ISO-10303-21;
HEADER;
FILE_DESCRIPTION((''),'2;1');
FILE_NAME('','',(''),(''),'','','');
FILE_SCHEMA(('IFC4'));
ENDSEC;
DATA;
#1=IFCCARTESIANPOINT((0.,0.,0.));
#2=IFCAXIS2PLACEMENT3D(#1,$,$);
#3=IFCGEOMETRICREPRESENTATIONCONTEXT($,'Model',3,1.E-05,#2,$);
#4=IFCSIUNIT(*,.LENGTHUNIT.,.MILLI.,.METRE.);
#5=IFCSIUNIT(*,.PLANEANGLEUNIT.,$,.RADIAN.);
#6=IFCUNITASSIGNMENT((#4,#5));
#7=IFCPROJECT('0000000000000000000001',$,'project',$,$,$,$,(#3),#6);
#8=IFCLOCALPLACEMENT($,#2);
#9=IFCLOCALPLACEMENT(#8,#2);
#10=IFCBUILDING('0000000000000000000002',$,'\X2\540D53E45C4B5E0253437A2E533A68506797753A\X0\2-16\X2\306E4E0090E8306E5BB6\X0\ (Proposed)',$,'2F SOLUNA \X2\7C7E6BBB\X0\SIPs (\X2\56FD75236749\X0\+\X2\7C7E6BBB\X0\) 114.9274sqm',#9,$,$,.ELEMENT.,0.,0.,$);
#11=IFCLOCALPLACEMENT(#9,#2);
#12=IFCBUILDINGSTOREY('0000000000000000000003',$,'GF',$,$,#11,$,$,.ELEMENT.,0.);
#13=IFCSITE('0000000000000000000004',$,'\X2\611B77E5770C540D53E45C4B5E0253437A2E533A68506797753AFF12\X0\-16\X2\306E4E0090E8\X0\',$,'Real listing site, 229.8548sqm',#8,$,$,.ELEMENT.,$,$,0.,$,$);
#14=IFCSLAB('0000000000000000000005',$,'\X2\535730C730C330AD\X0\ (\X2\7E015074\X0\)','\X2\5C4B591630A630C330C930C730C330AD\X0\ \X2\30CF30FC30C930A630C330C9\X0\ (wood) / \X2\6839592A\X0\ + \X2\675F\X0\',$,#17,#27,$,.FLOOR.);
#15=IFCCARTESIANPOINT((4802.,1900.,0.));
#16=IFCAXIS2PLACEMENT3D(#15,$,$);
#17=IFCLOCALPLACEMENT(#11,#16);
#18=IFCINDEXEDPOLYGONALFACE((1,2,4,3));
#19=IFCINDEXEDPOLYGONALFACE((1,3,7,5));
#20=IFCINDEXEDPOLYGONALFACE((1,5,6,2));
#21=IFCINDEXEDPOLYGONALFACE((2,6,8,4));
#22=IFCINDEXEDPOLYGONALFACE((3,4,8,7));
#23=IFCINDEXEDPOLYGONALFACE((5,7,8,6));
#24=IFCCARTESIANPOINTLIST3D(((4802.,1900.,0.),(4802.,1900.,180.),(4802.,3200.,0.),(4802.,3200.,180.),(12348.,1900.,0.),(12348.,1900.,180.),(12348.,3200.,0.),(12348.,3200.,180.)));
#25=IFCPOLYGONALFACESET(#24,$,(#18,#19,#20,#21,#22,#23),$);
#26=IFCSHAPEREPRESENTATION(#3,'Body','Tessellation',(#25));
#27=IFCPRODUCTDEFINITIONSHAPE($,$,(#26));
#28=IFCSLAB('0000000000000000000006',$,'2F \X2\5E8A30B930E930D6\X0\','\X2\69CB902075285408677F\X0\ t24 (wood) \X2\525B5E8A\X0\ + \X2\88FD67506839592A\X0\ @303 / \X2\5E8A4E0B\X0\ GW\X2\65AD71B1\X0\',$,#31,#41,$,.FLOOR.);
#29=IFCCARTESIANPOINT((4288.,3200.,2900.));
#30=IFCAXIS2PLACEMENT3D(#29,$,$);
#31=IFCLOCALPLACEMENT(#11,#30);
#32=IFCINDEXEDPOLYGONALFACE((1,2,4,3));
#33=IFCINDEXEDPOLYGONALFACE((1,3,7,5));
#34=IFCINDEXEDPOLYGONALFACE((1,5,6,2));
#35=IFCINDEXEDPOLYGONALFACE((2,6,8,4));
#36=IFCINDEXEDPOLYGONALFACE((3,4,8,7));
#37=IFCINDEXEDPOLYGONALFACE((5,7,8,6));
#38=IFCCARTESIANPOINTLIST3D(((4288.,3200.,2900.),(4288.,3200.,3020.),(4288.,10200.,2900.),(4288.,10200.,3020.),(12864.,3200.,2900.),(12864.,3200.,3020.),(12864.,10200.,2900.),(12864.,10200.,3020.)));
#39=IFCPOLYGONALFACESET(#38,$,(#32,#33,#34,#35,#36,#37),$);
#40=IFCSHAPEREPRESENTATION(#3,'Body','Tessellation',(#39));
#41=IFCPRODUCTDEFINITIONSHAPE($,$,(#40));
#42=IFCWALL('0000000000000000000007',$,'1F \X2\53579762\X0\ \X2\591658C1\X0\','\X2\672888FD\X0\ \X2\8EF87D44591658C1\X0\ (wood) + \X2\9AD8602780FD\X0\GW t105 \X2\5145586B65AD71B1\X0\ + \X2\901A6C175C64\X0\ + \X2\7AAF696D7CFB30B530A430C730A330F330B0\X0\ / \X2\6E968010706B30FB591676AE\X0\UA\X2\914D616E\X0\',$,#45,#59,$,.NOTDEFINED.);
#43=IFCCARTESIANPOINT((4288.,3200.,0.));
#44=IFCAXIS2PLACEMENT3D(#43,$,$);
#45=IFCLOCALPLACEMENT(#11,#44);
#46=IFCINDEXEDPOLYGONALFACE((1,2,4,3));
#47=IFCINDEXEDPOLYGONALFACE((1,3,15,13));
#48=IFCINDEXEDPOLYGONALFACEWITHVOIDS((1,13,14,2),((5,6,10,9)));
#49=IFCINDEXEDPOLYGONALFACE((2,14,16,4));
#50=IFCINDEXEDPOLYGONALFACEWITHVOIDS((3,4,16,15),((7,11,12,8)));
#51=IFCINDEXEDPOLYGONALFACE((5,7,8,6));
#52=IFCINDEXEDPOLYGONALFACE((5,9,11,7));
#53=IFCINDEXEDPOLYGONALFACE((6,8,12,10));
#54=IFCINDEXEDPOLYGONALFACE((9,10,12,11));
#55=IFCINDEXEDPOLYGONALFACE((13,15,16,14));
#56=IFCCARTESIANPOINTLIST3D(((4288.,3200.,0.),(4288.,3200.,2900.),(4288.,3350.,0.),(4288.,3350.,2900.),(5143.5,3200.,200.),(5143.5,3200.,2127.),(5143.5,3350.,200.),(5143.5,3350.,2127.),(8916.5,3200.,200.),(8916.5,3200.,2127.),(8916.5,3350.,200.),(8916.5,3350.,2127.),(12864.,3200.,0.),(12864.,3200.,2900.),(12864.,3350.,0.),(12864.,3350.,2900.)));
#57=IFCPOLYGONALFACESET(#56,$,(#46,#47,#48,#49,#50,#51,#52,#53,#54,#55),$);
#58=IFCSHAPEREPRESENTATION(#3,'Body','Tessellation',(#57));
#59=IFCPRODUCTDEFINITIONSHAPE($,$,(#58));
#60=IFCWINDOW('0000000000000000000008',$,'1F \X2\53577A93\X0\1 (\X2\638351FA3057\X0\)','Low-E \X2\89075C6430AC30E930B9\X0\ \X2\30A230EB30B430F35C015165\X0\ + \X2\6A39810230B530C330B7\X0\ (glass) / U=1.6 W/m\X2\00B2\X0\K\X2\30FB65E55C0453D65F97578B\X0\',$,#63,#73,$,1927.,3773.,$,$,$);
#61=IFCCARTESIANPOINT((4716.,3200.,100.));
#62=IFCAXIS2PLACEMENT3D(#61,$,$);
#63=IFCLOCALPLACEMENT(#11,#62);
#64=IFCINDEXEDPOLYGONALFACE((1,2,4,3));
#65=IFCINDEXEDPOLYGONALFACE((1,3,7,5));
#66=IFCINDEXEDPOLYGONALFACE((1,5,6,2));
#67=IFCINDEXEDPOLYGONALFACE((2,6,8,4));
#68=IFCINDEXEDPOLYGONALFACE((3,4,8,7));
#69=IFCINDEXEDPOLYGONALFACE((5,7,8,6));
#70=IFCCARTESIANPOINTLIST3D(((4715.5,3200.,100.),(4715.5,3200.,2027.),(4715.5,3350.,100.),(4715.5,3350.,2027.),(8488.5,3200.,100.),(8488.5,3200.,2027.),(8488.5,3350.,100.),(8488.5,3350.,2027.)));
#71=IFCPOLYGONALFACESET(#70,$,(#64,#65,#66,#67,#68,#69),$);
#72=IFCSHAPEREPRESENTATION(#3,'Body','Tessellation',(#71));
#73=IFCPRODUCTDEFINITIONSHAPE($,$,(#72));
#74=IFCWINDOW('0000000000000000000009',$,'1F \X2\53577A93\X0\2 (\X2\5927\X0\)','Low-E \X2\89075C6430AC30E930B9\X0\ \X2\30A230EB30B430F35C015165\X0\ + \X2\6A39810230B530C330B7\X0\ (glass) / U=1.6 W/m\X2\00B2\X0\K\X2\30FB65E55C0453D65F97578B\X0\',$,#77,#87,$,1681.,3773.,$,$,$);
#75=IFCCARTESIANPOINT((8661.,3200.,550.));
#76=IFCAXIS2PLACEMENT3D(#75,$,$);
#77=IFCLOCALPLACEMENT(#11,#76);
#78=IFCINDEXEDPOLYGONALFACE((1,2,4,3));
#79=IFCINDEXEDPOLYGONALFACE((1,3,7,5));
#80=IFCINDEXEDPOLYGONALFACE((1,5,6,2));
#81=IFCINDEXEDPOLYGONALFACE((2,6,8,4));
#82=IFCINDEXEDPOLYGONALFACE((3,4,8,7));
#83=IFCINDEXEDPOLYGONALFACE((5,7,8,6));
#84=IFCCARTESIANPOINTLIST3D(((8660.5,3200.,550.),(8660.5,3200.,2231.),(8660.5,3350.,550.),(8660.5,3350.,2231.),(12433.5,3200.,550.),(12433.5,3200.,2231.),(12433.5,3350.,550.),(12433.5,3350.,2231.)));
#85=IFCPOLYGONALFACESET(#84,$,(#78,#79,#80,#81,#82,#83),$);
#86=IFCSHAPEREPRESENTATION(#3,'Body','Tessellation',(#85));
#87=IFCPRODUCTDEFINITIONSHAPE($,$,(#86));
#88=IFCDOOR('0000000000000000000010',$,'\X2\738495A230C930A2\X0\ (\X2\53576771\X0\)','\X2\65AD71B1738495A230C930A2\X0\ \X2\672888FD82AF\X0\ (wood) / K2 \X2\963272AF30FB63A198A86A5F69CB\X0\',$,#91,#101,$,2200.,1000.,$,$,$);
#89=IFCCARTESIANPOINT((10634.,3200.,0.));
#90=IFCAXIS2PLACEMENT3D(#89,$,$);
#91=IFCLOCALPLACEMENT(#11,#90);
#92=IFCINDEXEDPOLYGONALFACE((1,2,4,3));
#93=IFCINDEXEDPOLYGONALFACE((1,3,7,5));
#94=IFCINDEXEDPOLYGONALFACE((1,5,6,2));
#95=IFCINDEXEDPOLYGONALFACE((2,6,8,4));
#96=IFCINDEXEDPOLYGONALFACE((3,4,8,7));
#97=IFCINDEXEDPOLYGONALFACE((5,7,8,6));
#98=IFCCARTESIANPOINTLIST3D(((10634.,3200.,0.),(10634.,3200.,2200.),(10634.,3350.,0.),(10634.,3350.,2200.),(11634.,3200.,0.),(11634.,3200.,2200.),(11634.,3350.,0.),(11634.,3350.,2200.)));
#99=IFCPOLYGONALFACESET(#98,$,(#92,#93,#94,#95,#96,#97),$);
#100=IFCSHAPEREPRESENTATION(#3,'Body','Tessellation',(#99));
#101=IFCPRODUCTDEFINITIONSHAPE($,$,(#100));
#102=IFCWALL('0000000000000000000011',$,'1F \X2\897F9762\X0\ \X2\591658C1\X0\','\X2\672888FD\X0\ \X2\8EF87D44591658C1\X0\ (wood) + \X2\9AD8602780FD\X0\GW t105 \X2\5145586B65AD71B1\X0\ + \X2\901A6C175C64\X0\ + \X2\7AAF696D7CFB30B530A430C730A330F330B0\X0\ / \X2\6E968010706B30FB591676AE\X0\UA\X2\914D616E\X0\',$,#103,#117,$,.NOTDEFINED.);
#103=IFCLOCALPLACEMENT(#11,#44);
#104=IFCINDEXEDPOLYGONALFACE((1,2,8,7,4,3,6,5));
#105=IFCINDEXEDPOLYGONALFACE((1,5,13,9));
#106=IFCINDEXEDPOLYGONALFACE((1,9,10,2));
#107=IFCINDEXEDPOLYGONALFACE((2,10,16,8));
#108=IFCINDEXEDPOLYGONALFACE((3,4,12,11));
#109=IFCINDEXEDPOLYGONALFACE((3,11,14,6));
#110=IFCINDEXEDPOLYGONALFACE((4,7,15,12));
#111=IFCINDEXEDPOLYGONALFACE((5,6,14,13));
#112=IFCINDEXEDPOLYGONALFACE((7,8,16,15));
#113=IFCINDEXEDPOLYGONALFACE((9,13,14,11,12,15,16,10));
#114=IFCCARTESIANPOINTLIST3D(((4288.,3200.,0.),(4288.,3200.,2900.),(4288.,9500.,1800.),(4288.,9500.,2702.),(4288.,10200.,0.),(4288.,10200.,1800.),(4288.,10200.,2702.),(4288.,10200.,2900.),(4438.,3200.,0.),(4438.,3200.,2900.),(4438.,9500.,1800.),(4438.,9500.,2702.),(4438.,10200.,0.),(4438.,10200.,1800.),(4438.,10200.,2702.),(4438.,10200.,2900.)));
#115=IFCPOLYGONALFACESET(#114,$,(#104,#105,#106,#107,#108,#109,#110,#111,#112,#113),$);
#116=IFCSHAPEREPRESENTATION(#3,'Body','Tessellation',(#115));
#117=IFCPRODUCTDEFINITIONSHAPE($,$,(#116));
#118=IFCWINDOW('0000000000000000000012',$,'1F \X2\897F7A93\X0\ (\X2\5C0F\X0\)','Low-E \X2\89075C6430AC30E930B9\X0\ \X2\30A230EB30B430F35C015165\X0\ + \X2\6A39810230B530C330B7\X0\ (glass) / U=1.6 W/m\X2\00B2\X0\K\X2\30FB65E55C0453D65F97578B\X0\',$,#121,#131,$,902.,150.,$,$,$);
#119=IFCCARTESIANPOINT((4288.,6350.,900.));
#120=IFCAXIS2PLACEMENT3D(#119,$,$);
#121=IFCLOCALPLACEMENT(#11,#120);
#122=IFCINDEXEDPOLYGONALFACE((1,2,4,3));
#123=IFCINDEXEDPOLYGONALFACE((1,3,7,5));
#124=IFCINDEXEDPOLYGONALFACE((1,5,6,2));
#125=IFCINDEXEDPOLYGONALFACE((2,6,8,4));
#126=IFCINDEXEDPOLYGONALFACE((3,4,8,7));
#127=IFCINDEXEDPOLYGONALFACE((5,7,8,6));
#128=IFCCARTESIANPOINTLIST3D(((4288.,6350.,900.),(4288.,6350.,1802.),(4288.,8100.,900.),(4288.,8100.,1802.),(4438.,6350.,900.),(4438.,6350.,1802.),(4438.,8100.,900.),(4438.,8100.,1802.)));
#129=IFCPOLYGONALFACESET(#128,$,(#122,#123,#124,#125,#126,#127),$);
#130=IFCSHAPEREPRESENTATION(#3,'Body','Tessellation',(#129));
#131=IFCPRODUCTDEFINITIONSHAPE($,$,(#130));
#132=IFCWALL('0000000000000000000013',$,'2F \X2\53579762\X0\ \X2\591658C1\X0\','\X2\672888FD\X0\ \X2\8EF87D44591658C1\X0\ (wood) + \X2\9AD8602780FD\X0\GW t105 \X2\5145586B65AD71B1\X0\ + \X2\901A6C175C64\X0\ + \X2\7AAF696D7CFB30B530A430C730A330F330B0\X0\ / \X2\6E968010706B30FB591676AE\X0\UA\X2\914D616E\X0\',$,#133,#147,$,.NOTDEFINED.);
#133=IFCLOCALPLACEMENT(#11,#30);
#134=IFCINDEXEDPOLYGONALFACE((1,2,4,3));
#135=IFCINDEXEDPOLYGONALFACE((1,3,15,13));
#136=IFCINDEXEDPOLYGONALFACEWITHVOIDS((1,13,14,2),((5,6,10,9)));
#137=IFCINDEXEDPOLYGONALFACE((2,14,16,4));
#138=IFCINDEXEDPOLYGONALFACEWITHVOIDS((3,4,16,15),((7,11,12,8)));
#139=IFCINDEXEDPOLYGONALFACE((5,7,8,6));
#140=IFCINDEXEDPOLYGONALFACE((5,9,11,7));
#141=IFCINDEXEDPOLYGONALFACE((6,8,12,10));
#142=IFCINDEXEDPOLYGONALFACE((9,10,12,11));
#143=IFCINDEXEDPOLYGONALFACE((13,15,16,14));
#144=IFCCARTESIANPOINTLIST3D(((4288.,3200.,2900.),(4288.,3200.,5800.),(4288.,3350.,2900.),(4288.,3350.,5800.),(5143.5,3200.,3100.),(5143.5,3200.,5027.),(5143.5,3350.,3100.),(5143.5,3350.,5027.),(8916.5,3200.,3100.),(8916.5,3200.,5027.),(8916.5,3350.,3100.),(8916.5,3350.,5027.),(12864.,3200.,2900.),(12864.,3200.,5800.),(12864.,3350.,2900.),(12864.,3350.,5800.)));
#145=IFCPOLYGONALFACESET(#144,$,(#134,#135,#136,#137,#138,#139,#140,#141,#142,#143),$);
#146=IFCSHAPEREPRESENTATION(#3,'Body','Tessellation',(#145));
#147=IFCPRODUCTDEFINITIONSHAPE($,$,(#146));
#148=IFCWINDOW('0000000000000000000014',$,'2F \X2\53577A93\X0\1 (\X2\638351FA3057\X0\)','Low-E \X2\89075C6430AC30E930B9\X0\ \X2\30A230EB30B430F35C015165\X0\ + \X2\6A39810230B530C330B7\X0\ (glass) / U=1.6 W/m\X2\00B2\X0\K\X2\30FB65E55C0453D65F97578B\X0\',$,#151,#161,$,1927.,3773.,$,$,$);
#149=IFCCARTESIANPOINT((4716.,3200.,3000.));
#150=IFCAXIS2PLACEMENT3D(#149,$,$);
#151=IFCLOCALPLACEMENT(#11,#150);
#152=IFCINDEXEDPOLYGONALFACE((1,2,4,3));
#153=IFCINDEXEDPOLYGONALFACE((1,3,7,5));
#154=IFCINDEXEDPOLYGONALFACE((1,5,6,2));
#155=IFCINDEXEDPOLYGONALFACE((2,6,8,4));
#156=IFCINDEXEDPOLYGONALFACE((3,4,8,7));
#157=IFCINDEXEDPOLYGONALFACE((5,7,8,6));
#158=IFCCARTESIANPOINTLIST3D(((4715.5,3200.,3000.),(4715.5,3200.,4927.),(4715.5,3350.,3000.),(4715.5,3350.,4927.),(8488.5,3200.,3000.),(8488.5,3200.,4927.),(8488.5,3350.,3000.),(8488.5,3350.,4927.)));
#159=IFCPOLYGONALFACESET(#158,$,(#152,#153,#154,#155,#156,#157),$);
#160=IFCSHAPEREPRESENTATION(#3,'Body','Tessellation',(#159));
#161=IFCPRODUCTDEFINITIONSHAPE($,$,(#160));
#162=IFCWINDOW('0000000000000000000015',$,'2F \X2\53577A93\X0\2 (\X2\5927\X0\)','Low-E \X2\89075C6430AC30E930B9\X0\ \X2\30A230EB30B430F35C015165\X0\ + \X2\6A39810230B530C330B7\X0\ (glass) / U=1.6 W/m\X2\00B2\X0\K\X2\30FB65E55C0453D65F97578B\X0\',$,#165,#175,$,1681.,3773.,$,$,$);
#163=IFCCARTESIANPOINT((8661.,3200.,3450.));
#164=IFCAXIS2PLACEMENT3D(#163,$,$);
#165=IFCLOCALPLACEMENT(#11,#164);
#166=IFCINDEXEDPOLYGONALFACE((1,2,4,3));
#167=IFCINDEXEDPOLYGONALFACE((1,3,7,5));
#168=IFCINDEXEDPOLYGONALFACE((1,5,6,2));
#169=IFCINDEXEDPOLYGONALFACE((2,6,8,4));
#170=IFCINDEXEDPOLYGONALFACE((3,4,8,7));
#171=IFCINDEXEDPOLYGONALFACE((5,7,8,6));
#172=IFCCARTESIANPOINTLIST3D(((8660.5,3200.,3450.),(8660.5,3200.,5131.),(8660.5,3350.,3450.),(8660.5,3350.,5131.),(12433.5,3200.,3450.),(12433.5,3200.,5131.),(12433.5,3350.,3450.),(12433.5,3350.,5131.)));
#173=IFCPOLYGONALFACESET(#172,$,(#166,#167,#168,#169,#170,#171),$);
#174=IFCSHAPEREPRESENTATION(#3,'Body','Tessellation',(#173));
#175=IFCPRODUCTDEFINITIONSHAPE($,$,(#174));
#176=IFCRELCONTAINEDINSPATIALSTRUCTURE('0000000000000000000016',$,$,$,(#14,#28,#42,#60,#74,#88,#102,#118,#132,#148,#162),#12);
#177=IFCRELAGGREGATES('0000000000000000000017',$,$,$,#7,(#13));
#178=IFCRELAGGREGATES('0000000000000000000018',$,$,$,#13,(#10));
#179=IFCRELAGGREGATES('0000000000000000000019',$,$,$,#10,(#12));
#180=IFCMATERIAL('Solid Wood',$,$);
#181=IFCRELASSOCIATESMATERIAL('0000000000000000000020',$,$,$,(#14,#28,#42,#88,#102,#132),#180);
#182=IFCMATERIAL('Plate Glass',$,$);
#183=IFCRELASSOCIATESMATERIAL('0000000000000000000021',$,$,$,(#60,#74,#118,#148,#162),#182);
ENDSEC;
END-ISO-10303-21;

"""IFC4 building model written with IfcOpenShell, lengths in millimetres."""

from ifc_helpers import new_model, si_unit, frame, frame_2d, origin, place, context, project, spatial, rectangle, extrude, material, element, fill, save


model = new_model("IFC4")

# Units and contexts
model_context = context("Model", 3, precision=1e-05, world=origin())
ifc_project = project(units=[si_unit("LENGTHUNIT", "METRE", prefix="MILLI"), si_unit("PLANEANGLEUNIT", "RADIAN")], contexts=[model_context])

# Site, building, storey
site_placement = place(None, origin())
site = spatial("IfcSite", under=ifc_project, at=site_placement, Name="愛知県名古屋市千種区桐林町２-16の一部", ObjectType="Real listing site, 229.8548sqm", CompositionType="ELEMENT", RefElevation=0.0)
building_placement = place(site_placement, origin())
building = spatial("IfcBuilding", under=site, at=building_placement, Name="名古屋市千種区桐林町2-16の一部の家 (Proposed)", ObjectType="2F SOLUNA 籾殻SIPs (国産杉+籾殻) 114.9274sqm", CompositionType="ELEMENT", ElevationOfRefHeight=0.0, ElevationOfTerrain=0.0)
storey_placement = place(building_placement, origin())
storey = spatial("IfcBuildingStorey", under=building, at=storey_placement, Name="GF", CompositionType="ELEMENT", Elevation=0.0)

# Slabs
ifc_material_1 = material(Name="Solid Wood")
slab_1_placement = place(storey_placement, frame((4802.0, 1900.0, 0.0)))
element("IfcSlab", 1, at=slab_1_placement, inside=storey, material=ifc_material_1, Name="南デッキ (縁側)", Description="屋外ウッドデッキ ハードウッド (wood) / 根太 + 束", PredefinedType="FLOOR", context=model_context, shape_type="SweptSolid", body=[
    extrude(rectangle(XDim=7546.0, YDim=1300.0, at=frame_2d((3773.0, 650.0))), frame((4802.0, 1900.0, 0.0)), (0.0, 0.0, 1.0), 180.0),
])
slab_2_placement = place(storey_placement, frame((4288.0, 3200.0, 2900.0)))
element("IfcSlab", 2, at=slab_2_placement, inside=storey, material=ifc_material_1, Name="2F 床スラブ", Description="構造用合板 t24 (wood) 剛床 + 製材根太 @303 / 床下 GW断熱", PredefinedType="FLOOR", context=model_context, shape_type="SweptSolid", body=[
    extrude(rectangle(XDim=8576.0, YDim=7000.0, at=frame_2d((4288.0, 3500.0))), frame((4288.0, 3200.0, 2900.0)), (0.0, 0.0, 1.0), 120.0),
])

# Wall, openings, windows, door
wall_1_placement = place(storey_placement, frame((4288.0, 3200.0, 0.0)))
wall_1 = element("IfcWall", 3, at=wall_1_placement, inside=storey, material=ifc_material_1, Name="1F 南面 外壁", Description="木製 軸組外壁 (wood) + 高性能GW t105 充填断熱 + 通気層 + 窯業系サイディング / 準耐火・外皮UA配慮", PredefinedType="NOTDEFINED", context=model_context, shape_type="SweptSolid", body=[
    extrude(rectangle(XDim=8576.0, YDim=150.0, at=frame_2d((4288.0, 75.0))), frame((4288.0, 3200.0, 0.0)), (0.0, 0.0, 1.0), 2900.0),
])
opening_1_placement = place(storey_placement, frame((4716.0, 3200.0, 100.0)))
opening_1 = element("IfcOpeningElement", 4, at=opening_1_placement, cuts=wall_1, PredefinedType="NOTDEFINED", context=model_context, shape_type="SweptSolid", body=[
    extrude(rectangle(XDim=3773.0, YDim=150.0, at=frame_2d((1886.0, 75.0))), frame((4716.0, 3200.0, 100.0)), (0.0, 0.0, 1.0), 1927.0),
])
opening_2_placement = place(storey_placement, frame((8661.0, 3200.0, 550.0)))
opening_2 = element("IfcOpeningElement", 5, at=opening_2_placement, cuts=wall_1, PredefinedType="NOTDEFINED", context=model_context, shape_type="SweptSolid", body=[
    extrude(rectangle(XDim=3773.0, YDim=150.0, at=frame_2d((1886.0, 75.0))), frame((8661.0, 3200.0, 550.0)), (0.0, 0.0, 1.0), 1681.0),
])
opening_3_placement = place(storey_placement, frame((10634.0, 3200.0, 0.0)))
opening_3 = element("IfcOpeningElement", 6, at=opening_3_placement, cuts=wall_1, PredefinedType="NOTDEFINED", context=model_context, shape_type="SweptSolid", body=[
    extrude(rectangle(XDim=1000.0, YDim=150.0, at=frame_2d((500.0, 75.0))), frame((10634.0, 3200.0, 0.0)), (0.0, 0.0, 1.0), 2200.0),
])
ifc_material_2 = material(Name="Plate Glass")
window_1_placement = place(storey_placement, frame((4716.0, 3200.0, 100.0)))
window_1 = element("IfcWindow", 7, at=window_1_placement, inside=storey, material=ifc_material_2, Name="1F 南窓1 (掃出し)", Description="Low-E 複層ガラス アルゴン封入 + 樹脂サッシ (glass) / U=1.6 W/m²K・日射取得型", OverallHeight=1927.0, OverallWidth=3773.0, context=model_context, shape_type="SweptSolid", body=[
    extrude(rectangle(XDim=3773.0, YDim=150.0, at=frame_2d((1886.0, 75.0))), frame((4716.0, 3200.0, 100.0)), (0.0, 0.0, 1.0), 1927.0),
])
fill(opening_1, window_1)
window_2_placement = place(storey_placement, frame((8661.0, 3200.0, 550.0)))
window_2 = element("IfcWindow", 8, at=window_2_placement, inside=storey, material=ifc_material_2, Name="1F 南窓2 (大)", Description="Low-E 複層ガラス アルゴン封入 + 樹脂サッシ (glass) / U=1.6 W/m²K・日射取得型", OverallHeight=1681.0, OverallWidth=3773.0, context=model_context, shape_type="SweptSolid", body=[
    extrude(rectangle(XDim=3773.0, YDim=150.0, at=frame_2d((1886.0, 75.0))), frame((8661.0, 3200.0, 550.0)), (0.0, 0.0, 1.0), 1681.0),
])
fill(opening_2, window_2)
door_placement = place(storey_placement, frame((10634.0, 3200.0, 0.0)))
door = element("IfcDoor", 9, at=door_placement, inside=storey, material=ifc_material_1, Name="玄関ドア (南東)", Description="断熱玄関ドア 木製芯 (wood) / K2 防犯・採風機構", OverallHeight=2200.0, OverallWidth=1000.0, context=model_context, shape_type="SweptSolid", body=[
    extrude(rectangle(XDim=1000.0, YDim=150.0, at=frame_2d((500.0, 75.0))), frame((10634.0, 3200.0, 0.0)), (0.0, 0.0, 1.0), 2200.0),
])
fill(opening_3, door)

# Wall, opening, window
wall_2_placement = place(storey_placement, frame((4288.0, 3200.0, 0.0)))
wall_2 = element("IfcWall", 10, at=wall_2_placement, inside=storey, material=ifc_material_1, Name="1F 西面 外壁", Description="木製 軸組外壁 (wood) + 高性能GW t105 充填断熱 + 通気層 + 窯業系サイディング / 準耐火・外皮UA配慮", PredefinedType="NOTDEFINED", context=model_context, shape_type="SweptSolid", body=[
    extrude(rectangle(XDim=150.0, YDim=7000.0, at=frame_2d((75.0, 3500.0))), frame((4288.0, 3200.0, 0.0)), (0.0, 0.0, 1.0), 2900.0),
])
opening_4_placement = place(storey_placement, frame((4288.0, 6350.0, 900.0)))
opening_4 = element("IfcOpeningElement", 11, at=opening_4_placement, cuts=wall_2, PredefinedType="NOTDEFINED", context=model_context, shape_type="SweptSolid", body=[
    extrude(rectangle(XDim=150.0, YDim=1750.0, at=frame_2d((75.0, 875.0))), frame((4288.0, 6350.0, 900.0)), (0.0, 0.0, 1.0), 902.0),
])
window_3_placement = place(storey_placement, frame((4288.0, 6350.0, 900.0)))
window_3 = element("IfcWindow", 12, at=window_3_placement, inside=storey, material=ifc_material_2, Name="1F 西窓 (小)", Description="Low-E 複層ガラス アルゴン封入 + 樹脂サッシ (glass) / U=1.6 W/m²K・日射取得型", OverallHeight=902.0, OverallWidth=150.0, context=model_context, shape_type="SweptSolid", body=[
    extrude(rectangle(XDim=150.0, YDim=1750.0, at=frame_2d((75.0, 875.0))), frame((4288.0, 6350.0, 900.0)), (0.0, 0.0, 1.0), 902.0),
])
fill(opening_4, window_3)

# Wall, openings, windows
wall_3_placement = place(storey_placement, frame((4288.0, 3200.0, 2900.0)))
wall_3 = element("IfcWall", 13, at=wall_3_placement, inside=storey, material=ifc_material_1, Name="2F 南面 外壁", Description="木製 軸組外壁 (wood) + 高性能GW t105 充填断熱 + 通気層 + 窯業系サイディング / 準耐火・外皮UA配慮", PredefinedType="NOTDEFINED", context=model_context, shape_type="SweptSolid", body=[
    extrude(rectangle(XDim=8576.0, YDim=150.0, at=frame_2d((4288.0, 75.0))), frame((4288.0, 3200.0, 2900.0)), (0.0, 0.0, 1.0), 2900.0),
])
opening_5_placement = place(storey_placement, frame((4716.0, 3200.0, 3000.0)))
opening_5 = element("IfcOpeningElement", 14, at=opening_5_placement, cuts=wall_3, PredefinedType="NOTDEFINED", context=model_context, shape_type="SweptSolid", body=[
    extrude(rectangle(XDim=3773.0, YDim=150.0, at=frame_2d((1886.0, 75.0))), frame((4716.0, 3200.0, 3000.0)), (0.0, 0.0, 1.0), 1927.0),
])
opening_6_placement = place(storey_placement, frame((8661.0, 3200.0, 3450.0)))
opening_6 = element("IfcOpeningElement", 15, at=opening_6_placement, cuts=wall_3, PredefinedType="NOTDEFINED", context=model_context, shape_type="SweptSolid", body=[
    extrude(rectangle(XDim=3773.0, YDim=150.0, at=frame_2d((1886.0, 75.0))), frame((8661.0, 3200.0, 3450.0)), (0.0, 0.0, 1.0), 1681.0),
])
window_4_placement = place(storey_placement, frame((4716.0, 3200.0, 3000.0)))
window_4 = element("IfcWindow", 16, at=window_4_placement, inside=storey, material=ifc_material_2, Name="2F 南窓1 (掃出し)", Description="Low-E 複層ガラス アルゴン封入 + 樹脂サッシ (glass) / U=1.6 W/m²K・日射取得型", OverallHeight=1927.0, OverallWidth=3773.0, context=model_context, shape_type="SweptSolid", body=[
    extrude(rectangle(XDim=3773.0, YDim=150.0, at=frame_2d((1886.0, 75.0))), frame((4716.0, 3200.0, 3000.0)), (0.0, 0.0, 1.0), 1927.0),
])
fill(opening_5, window_4)
window_5_placement = place(storey_placement, frame((8661.0, 3200.0, 3450.0)))
window_5 = element("IfcWindow", 17, at=window_5_placement, inside=storey, material=ifc_material_2, Name="2F 南窓2 (大)", Description="Low-E 複層ガラス アルゴン封入 + 樹脂サッシ (glass) / U=1.6 W/m²K・日射取得型", OverallHeight=1681.0, OverallWidth=3773.0, context=model_context, shape_type="SweptSolid", body=[
    extrude(rectangle(XDim=3773.0, YDim=150.0, at=frame_2d((1886.0, 75.0))), frame((8661.0, 3200.0, 3450.0)), (0.0, 0.0, 1.0), 1681.0),
])
fill(opening_6, window_5)

save(model, "model.ifc")
